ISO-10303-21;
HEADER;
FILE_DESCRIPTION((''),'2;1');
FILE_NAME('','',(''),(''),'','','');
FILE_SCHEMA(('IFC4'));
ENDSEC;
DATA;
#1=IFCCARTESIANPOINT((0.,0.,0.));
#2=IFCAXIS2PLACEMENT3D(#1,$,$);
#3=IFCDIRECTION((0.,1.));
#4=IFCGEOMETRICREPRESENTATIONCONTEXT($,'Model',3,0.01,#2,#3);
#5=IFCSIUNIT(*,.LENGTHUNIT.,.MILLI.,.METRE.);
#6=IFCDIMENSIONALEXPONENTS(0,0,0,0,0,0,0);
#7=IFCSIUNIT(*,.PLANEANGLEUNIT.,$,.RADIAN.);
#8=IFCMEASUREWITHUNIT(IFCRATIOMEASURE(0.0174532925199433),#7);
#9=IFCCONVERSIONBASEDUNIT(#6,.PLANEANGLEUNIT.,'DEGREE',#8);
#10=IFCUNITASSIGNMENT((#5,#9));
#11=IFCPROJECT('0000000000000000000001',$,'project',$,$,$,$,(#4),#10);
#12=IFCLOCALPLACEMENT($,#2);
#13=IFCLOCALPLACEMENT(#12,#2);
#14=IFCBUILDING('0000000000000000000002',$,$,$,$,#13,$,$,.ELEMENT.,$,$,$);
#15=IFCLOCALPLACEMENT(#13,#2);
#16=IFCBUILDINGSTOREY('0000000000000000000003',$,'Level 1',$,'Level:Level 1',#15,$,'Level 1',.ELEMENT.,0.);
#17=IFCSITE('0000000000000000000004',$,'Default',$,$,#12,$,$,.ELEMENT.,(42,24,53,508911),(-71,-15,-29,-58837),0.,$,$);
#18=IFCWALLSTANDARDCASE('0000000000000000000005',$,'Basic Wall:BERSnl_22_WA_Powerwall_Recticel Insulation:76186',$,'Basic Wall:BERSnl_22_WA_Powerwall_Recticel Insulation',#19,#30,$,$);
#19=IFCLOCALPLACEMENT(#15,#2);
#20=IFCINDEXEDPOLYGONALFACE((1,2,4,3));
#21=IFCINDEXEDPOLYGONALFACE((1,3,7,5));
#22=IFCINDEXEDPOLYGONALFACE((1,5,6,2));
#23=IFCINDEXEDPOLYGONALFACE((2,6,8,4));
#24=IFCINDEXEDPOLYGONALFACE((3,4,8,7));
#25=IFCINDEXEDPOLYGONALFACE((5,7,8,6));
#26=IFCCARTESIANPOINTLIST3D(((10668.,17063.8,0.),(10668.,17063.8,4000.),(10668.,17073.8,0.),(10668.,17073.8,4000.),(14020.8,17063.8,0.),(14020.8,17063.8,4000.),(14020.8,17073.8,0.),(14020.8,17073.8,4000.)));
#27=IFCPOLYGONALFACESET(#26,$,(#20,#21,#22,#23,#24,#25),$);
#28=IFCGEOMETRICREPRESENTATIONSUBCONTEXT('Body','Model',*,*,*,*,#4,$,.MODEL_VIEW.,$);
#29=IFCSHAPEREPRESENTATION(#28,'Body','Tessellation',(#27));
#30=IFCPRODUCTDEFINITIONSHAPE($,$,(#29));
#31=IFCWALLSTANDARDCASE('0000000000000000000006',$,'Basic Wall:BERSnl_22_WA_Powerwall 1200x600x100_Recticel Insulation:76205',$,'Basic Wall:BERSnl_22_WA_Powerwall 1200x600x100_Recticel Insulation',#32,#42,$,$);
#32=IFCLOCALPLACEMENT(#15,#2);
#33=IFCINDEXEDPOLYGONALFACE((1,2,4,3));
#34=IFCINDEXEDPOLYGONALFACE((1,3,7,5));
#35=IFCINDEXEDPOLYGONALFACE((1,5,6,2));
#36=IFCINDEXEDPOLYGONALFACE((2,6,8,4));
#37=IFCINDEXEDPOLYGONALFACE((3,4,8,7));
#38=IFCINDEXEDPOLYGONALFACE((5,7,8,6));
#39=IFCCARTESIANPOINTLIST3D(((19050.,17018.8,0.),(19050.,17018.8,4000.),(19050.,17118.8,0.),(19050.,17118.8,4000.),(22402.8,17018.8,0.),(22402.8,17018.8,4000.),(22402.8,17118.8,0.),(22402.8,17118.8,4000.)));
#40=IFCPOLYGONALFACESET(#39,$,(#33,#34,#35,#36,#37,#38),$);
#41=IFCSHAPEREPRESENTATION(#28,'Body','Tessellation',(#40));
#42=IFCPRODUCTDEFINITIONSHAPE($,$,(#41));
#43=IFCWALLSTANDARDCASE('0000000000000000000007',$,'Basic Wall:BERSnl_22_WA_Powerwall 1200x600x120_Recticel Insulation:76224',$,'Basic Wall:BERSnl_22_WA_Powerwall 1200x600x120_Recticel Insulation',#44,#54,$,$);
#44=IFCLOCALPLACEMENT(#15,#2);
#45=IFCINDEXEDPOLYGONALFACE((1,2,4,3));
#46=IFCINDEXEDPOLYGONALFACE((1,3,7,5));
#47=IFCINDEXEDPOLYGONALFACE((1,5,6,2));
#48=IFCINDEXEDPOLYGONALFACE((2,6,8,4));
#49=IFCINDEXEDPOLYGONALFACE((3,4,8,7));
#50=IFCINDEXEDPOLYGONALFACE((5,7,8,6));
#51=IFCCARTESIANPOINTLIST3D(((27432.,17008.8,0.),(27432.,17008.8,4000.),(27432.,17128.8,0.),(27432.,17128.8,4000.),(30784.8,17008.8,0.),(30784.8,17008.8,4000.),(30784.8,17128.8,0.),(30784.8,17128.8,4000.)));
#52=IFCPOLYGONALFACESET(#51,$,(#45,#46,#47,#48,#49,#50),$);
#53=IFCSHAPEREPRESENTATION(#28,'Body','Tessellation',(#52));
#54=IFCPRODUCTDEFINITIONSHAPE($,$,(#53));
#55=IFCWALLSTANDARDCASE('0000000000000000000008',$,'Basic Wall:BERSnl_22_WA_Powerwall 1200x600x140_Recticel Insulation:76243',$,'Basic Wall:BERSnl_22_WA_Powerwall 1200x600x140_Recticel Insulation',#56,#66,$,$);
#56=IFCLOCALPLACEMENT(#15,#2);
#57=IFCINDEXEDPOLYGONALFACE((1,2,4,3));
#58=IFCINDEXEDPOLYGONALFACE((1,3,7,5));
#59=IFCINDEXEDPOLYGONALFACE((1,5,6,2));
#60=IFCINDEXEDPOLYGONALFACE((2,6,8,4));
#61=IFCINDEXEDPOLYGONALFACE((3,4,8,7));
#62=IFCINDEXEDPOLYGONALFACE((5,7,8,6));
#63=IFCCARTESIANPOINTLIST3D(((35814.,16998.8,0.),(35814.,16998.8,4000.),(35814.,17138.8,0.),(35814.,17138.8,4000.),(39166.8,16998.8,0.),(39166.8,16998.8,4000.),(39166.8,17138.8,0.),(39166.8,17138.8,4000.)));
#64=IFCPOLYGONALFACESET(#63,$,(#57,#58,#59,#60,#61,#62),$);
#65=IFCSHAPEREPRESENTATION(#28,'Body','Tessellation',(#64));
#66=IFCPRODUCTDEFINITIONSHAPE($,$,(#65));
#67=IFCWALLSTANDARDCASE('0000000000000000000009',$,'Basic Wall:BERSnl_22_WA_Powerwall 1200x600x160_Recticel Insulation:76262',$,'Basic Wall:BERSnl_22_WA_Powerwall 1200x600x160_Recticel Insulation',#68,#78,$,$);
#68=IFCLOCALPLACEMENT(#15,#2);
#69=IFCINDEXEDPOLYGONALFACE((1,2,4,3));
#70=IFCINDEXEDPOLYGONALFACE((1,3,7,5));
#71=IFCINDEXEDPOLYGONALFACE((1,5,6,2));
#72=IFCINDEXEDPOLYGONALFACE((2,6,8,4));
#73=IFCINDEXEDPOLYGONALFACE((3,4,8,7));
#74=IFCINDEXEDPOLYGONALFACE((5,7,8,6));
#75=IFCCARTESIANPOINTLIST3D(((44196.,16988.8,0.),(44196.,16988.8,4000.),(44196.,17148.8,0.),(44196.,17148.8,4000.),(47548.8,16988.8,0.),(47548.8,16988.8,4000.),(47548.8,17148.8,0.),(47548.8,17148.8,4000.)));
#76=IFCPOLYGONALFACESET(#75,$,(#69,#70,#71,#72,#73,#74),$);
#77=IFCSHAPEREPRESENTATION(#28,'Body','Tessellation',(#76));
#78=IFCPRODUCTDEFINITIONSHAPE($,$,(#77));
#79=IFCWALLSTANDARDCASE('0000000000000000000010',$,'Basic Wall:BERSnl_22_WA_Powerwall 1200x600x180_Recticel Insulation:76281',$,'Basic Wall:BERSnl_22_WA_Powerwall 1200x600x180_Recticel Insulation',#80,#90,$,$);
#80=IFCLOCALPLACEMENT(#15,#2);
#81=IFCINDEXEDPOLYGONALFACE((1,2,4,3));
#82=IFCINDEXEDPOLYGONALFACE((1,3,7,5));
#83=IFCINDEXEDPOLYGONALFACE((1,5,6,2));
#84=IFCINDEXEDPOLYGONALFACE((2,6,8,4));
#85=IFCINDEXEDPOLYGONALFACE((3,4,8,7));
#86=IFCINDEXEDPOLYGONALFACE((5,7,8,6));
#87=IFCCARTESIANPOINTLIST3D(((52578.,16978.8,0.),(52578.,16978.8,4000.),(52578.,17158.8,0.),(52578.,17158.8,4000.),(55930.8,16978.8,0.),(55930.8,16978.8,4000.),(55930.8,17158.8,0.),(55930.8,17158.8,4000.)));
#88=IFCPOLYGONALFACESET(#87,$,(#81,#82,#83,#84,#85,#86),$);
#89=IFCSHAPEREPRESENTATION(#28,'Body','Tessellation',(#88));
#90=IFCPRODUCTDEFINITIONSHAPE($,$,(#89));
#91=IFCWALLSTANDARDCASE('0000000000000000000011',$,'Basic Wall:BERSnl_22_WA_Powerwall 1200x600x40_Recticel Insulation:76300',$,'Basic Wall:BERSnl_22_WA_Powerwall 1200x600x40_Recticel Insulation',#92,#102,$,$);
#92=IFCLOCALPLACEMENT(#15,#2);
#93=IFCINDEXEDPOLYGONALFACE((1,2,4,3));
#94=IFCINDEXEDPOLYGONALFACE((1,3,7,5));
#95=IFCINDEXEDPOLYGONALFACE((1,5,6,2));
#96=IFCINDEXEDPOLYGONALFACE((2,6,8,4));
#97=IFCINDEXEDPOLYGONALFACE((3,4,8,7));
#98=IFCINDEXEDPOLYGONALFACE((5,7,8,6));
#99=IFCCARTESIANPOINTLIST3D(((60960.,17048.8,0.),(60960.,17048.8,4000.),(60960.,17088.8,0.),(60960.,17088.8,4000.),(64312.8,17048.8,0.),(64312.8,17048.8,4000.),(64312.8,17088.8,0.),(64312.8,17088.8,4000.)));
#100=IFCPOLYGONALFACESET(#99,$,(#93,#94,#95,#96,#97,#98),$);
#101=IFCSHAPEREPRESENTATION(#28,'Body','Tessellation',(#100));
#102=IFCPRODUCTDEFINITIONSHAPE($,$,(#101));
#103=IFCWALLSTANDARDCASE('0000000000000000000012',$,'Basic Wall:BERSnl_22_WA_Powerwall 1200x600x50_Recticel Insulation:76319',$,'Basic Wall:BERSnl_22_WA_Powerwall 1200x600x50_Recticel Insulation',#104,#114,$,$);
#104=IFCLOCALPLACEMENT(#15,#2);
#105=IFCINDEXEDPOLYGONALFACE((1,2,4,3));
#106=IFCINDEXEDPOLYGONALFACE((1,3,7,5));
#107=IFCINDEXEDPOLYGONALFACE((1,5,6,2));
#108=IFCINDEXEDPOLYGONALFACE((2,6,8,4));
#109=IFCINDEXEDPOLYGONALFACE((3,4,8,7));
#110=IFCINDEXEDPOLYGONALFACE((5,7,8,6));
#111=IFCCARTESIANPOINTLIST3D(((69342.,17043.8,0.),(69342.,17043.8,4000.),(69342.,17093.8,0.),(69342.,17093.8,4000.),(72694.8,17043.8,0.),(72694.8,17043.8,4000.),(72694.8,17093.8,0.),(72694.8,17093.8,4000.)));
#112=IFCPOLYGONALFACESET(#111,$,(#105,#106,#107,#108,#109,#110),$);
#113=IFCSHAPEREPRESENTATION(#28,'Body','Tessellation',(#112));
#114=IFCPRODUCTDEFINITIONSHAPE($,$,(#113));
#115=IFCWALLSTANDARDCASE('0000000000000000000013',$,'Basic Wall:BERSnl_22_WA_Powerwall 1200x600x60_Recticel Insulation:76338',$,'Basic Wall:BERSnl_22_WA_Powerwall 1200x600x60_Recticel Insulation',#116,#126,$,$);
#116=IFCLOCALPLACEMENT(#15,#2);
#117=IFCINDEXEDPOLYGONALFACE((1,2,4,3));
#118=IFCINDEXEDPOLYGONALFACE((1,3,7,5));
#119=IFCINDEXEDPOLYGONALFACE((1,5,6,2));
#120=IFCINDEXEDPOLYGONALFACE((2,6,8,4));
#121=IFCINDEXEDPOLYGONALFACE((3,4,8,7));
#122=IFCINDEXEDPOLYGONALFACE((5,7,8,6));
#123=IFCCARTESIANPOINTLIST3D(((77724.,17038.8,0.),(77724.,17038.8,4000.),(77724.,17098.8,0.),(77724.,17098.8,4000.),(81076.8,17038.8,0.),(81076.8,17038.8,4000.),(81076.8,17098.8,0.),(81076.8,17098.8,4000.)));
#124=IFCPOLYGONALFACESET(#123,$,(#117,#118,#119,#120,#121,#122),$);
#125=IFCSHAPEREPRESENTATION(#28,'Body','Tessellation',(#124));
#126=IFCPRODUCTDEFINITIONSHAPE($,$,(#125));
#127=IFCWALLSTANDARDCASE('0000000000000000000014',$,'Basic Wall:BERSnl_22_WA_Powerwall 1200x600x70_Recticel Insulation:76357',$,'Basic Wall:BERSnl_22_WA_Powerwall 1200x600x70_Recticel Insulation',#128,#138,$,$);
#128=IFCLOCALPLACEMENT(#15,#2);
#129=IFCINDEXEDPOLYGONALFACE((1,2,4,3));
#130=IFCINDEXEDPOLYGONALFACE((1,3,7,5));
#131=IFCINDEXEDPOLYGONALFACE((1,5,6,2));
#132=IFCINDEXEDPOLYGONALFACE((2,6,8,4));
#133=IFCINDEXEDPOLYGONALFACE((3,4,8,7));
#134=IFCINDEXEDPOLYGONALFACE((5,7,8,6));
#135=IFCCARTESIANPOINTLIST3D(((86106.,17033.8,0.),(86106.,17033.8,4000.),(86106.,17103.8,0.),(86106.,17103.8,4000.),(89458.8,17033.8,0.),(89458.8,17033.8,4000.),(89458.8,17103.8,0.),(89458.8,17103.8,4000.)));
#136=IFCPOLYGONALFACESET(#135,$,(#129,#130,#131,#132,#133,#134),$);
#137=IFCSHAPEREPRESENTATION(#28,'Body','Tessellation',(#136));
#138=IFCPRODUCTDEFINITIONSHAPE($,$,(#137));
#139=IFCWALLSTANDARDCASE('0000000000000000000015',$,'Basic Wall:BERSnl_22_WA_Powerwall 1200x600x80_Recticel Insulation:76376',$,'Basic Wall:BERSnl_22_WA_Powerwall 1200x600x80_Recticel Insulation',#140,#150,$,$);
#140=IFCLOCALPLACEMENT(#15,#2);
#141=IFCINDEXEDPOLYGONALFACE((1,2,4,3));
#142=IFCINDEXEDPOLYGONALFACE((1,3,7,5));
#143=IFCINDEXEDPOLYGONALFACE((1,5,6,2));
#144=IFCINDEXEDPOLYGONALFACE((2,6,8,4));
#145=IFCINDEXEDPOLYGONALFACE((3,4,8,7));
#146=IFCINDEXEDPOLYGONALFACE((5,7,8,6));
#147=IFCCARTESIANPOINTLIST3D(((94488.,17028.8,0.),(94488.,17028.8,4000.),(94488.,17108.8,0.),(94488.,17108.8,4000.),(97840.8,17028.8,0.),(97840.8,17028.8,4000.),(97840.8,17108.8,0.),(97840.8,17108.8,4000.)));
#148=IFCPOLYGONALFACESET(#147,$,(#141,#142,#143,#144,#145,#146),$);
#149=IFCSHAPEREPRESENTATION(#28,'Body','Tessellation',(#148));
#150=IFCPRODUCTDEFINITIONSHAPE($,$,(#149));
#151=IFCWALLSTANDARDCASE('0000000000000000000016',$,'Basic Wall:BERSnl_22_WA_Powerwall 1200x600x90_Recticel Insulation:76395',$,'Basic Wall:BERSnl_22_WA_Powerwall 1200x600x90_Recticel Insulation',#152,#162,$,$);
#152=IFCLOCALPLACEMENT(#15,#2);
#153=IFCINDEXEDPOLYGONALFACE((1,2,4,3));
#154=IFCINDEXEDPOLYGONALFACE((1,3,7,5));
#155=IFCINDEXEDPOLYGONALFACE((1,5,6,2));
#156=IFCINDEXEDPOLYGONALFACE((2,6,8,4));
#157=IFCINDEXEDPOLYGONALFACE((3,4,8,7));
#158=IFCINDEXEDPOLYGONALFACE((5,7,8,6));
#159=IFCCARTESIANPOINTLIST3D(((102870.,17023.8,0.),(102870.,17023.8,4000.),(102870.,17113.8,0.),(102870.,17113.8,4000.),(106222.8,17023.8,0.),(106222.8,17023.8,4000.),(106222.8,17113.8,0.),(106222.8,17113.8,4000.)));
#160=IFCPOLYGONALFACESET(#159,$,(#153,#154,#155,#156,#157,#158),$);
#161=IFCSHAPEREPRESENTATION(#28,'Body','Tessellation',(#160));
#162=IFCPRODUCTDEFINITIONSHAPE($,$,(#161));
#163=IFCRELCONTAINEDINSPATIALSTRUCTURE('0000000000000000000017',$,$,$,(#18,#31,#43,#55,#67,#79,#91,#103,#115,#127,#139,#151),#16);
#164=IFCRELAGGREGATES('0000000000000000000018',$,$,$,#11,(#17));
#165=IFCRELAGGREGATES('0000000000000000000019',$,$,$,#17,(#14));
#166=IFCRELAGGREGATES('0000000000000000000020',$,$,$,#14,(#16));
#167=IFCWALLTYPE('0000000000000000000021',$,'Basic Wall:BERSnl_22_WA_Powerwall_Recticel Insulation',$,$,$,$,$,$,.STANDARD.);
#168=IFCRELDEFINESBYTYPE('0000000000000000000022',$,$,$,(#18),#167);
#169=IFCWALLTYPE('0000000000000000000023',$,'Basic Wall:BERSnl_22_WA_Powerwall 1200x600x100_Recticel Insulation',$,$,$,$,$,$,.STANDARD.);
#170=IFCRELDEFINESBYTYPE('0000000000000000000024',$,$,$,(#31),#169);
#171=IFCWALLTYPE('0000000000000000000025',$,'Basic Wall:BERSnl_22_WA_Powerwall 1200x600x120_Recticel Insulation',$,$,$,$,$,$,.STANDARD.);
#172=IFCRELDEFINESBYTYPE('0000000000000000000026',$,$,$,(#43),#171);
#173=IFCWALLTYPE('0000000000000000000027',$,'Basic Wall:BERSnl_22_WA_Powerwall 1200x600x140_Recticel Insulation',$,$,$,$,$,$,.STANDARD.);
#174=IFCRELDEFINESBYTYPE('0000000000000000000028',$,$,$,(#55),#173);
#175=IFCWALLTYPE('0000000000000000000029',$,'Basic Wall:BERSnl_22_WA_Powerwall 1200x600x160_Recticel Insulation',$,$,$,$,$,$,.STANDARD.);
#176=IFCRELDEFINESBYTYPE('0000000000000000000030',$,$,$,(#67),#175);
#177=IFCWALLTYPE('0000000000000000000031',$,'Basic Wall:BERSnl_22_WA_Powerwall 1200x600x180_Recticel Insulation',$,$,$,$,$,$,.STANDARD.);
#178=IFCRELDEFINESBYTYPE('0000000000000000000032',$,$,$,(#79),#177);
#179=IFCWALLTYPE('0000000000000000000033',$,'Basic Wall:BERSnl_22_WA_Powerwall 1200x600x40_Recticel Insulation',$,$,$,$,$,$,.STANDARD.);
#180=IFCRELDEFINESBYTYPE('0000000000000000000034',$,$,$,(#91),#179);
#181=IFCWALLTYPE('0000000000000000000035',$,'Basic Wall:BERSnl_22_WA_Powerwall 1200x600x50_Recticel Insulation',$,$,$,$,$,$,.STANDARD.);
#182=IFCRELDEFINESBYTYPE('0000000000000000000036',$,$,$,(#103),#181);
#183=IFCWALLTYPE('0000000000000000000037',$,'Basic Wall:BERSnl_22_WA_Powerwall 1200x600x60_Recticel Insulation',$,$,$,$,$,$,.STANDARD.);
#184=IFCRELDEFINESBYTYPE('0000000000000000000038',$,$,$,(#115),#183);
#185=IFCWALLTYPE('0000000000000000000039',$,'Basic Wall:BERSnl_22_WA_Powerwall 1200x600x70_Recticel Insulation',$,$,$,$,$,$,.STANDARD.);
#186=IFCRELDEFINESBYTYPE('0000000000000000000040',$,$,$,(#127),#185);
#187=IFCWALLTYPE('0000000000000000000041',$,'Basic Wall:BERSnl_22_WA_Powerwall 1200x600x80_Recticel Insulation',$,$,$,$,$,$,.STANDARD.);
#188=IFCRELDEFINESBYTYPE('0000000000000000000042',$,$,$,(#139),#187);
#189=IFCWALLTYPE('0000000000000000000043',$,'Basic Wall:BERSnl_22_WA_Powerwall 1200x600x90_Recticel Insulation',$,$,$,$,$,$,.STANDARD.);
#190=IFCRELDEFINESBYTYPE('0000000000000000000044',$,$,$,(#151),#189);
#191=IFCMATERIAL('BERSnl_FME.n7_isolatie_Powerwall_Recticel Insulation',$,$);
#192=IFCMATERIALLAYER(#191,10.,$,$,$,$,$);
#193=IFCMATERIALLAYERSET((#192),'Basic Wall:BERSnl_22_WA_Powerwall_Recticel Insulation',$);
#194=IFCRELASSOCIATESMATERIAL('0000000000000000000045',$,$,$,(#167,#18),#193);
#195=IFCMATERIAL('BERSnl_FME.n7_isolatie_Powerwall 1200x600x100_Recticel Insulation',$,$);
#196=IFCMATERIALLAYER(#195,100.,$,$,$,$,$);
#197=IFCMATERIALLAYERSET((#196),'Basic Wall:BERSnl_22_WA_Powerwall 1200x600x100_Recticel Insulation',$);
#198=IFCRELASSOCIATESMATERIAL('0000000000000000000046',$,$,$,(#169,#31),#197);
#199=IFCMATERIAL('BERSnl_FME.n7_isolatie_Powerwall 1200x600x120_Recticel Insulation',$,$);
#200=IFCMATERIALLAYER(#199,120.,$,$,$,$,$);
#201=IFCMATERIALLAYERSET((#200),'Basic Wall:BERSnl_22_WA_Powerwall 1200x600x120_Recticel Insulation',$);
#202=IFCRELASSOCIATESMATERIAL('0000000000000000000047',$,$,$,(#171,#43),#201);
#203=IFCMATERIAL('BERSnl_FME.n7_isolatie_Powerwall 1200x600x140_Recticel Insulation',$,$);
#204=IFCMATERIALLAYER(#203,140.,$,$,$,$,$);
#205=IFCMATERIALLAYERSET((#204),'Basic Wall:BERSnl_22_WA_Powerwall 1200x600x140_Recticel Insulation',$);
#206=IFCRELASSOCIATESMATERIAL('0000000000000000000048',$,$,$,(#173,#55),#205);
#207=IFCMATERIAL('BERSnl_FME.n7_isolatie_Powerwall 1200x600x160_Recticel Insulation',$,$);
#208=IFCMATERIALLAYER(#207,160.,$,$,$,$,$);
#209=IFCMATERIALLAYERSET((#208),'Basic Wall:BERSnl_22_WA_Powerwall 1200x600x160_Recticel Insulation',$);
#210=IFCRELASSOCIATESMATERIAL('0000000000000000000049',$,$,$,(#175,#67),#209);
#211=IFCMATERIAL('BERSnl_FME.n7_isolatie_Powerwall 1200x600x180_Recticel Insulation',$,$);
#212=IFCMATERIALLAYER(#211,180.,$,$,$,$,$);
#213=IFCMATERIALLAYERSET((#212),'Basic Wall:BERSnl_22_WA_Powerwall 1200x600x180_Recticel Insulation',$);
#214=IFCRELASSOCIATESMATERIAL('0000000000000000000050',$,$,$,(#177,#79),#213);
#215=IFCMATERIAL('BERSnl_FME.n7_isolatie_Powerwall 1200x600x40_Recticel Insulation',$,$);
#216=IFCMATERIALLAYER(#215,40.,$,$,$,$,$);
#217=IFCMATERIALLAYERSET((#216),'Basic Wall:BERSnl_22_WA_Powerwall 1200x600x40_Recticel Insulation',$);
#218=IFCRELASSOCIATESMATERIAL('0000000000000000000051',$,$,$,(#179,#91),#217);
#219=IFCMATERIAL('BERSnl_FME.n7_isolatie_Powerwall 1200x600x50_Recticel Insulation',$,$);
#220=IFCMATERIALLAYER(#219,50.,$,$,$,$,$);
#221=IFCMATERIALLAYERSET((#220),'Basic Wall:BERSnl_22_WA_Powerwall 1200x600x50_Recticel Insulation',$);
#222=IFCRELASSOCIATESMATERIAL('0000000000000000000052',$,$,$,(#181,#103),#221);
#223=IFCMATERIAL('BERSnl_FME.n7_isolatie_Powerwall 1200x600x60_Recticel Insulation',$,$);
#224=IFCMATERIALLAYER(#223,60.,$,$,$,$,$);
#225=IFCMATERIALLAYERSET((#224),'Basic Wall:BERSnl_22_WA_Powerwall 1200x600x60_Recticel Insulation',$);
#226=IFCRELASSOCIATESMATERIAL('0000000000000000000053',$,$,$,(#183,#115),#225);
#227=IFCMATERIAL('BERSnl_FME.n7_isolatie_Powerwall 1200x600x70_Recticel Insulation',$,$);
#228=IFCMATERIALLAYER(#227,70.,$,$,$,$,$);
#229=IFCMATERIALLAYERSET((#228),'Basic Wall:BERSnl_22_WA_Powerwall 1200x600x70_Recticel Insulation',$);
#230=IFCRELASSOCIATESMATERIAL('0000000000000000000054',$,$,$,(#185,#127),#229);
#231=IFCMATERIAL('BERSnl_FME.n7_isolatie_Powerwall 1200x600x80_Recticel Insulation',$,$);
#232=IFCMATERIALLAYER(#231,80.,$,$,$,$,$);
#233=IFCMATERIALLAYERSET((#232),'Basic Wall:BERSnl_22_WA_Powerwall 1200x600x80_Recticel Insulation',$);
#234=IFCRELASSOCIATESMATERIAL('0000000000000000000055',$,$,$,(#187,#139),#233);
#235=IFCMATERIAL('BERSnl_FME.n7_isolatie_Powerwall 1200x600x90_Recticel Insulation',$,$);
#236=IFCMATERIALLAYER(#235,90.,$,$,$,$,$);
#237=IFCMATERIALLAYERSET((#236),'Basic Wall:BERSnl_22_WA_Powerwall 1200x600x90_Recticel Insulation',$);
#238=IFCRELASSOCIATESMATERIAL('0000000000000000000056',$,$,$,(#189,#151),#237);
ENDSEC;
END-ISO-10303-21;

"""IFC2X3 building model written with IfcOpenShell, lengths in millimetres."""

from ifc_helpers import new_model, entity, si_unit, converted_unit, direction, frame, frame_2d, origin, place, context, subcontext, project, spatial, rectangle, extrude, material, layer, layer_set, layer_usage, type_object, element, save


model = new_model("IFC2X3")

# Units and contexts
model_context = context("Model", 3, precision=0.01, world=origin(), true_north=direction((0.0, 1.0)))
body_context = subcontext(model_context, "Body", "Model", "MODEL_VIEW")
ifc_project = project(units=[si_unit("LENGTHUNIT", "METRE", prefix="MILLI"), converted_unit("PLANEANGLEUNIT", "DEGREE", entity("IfcRatioMeasure", 0.0174532925199433), si_unit("PLANEANGLEUNIT", "RADIAN"), dimensions=[0, 0, 0, 0, 0, 0, 0])], contexts=[model_context])

# Site, building, storey
site_placement = place(None, origin())
site = spatial("IfcSite", under=ifc_project, at=site_placement, Name="Default", CompositionType="ELEMENT", RefLatitude=(42, 24, 53, 508911), RefLongitude=(-71, -15, -29, -58837), RefElevation=0.0)
building_placement = place(site_placement, origin())
building = spatial("IfcBuilding", under=site, at=building_placement, CompositionType="ELEMENT")
storey_placement = place(building_placement, origin())
storey = spatial("IfcBuildingStorey", under=building, at=storey_placement, Name="Level 1", ObjectType="Level:Level 1", LongName="Level 1", CompositionType="ELEMENT", Elevation=0.0)

# Walls
ifc_material_1 = material(Name="BERSnl_FME.n7_isolatie_Powerwall_Recticel Insulation")
ifc_layer_1 = layer(ifc_material_1, 10.0)
ifc_layer_set_1 = layer_set([ifc_layer_1], Name="Basic Wall:BERSnl_22_WA_Powerwall_Recticel Insulation")
ifc_layer_usage_1 = layer_usage(ifc_layer_set_1, "AXIS2", "NEGATIVE", 5.0)
wall_type_1 = type_object("IfcWallType", Name="Basic Wall:BERSnl_22_WA_Powerwall_Recticel Insulation", PredefinedType="STANDARD", material=ifc_layer_set_1)
wall_1_placement = place(storey_placement, frame((10668.0, 17068.8, 0.0)))
element("IfcWallStandardCase", 1, at=wall_1_placement, inside=storey, type_object=wall_type_1, material=ifc_layer_usage_1, Name="Basic Wall:BERSnl_22_WA_Powerwall_Recticel Insulation:76186", ObjectType="Basic Wall:BERSnl_22_WA_Powerwall_Recticel Insulation", context=body_context, shape_type="SweptSolid", body=[
    extrude(rectangle(XDim=3352.8, YDim=10.0, at=frame_2d((1676.4, 0.0), x_axis=(-1.0, 0.0))), origin(), (0.0, 0.0, 1.0), 4000.0),
])
ifc_material_2 = material(Name="BERSnl_FME.n7_isolatie_Powerwall 1200x600x100_Recticel Insulation")
ifc_layer_2 = layer(ifc_material_2, 100.0)
ifc_layer_set_2 = layer_set([ifc_layer_2], Name="Basic Wall:BERSnl_22_WA_Powerwall 1200x600x100_Recticel Insulation")
ifc_layer_usage_2 = layer_usage(ifc_layer_set_2, "AXIS2", "NEGATIVE", 50.0)
wall_type_2 = type_object("IfcWallType", Name="Basic Wall:BERSnl_22_WA_Powerwall 1200x600x100_Recticel Insulation", PredefinedType="STANDARD", material=ifc_layer_set_2)
wall_2_placement = place(storey_placement, frame((19050.0, 17068.8, 0.0)))
element("IfcWallStandardCase", 2, at=wall_2_placement, inside=storey, type_object=wall_type_2, material=ifc_layer_usage_2, Name="Basic Wall:BERSnl_22_WA_Powerwall 1200x600x100_Recticel Insulation:76205", ObjectType="Basic Wall:BERSnl_22_WA_Powerwall 1200x600x100_Recticel Insulation", context=body_context, shape_type="SweptSolid", body=[
    extrude(rectangle(XDim=3352.8, YDim=100.0, at=frame_2d((1676.4, 0.0), x_axis=(-1.0, 0.0))), origin(), (0.0, 0.0, 1.0), 4000.0),
])
ifc_material_3 = material(Name="BERSnl_FME.n7_isolatie_Powerwall 1200x600x120_Recticel Insulation")
ifc_layer_3 = layer(ifc_material_3, 120.0)
ifc_layer_set_3 = layer_set([ifc_layer_3], Name="Basic Wall:BERSnl_22_WA_Powerwall 1200x600x120_Recticel Insulation")
ifc_layer_usage_3 = layer_usage(ifc_layer_set_3, "AXIS2", "NEGATIVE", 60.0)
wall_type_3 = type_object("IfcWallType", Name="Basic Wall:BERSnl_22_WA_Powerwall 1200x600x120_Recticel Insulation", PredefinedType="STANDARD", material=ifc_layer_set_3)
wall_3_placement = place(storey_placement, frame((27432.0, 17068.8, 0.0)))
element("IfcWallStandardCase", 3, at=wall_3_placement, inside=storey, type_object=wall_type_3, material=ifc_layer_usage_3, Name="Basic Wall:BERSnl_22_WA_Powerwall 1200x600x120_Recticel Insulation:76224", ObjectType="Basic Wall:BERSnl_22_WA_Powerwall 1200x600x120_Recticel Insulation", context=body_context, shape_type="SweptSolid", body=[
    extrude(rectangle(XDim=3352.8, YDim=120.0, at=frame_2d((1676.4, 0.0), x_axis=(-1.0, 0.0))), origin(), (0.0, 0.0, 1.0), 4000.0),
])
ifc_material_4 = material(Name="BERSnl_FME.n7_isolatie_Powerwall 1200x600x140_Recticel Insulation")
ifc_layer_4 = layer(ifc_material_4, 140.0)
ifc_layer_set_4 = layer_set([ifc_layer_4], Name="Basic Wall:BERSnl_22_WA_Powerwall 1200x600x140_Recticel Insulation")
ifc_layer_usage_4 = layer_usage(ifc_layer_set_4, "AXIS2", "NEGATIVE", 70.0)
wall_type_4 = type_object("IfcWallType", Name="Basic Wall:BERSnl_22_WA_Powerwall 1200x600x140_Recticel Insulation", PredefinedType="STANDARD", material=ifc_layer_set_4)
wall_4_placement = place(storey_placement, frame((35814.0, 17068.8, 0.0)))
element("IfcWallStandardCase", 4, at=wall_4_placement, inside=storey, type_object=wall_type_4, material=ifc_layer_usage_4, Name="Basic Wall:BERSnl_22_WA_Powerwall 1200x600x140_Recticel Insulation:76243", ObjectType="Basic Wall:BERSnl_22_WA_Powerwall 1200x600x140_Recticel Insulation", context=body_context, shape_type="SweptSolid", body=[
    extrude(rectangle(XDim=3352.8, YDim=140.0, at=frame_2d((1676.4, 0.0), x_axis=(-1.0, 0.0))), origin(), (0.0, 0.0, 1.0), 4000.0),
])
ifc_material_5 = material(Name="BERSnl_FME.n7_isolatie_Powerwall 1200x600x160_Recticel Insulation")
ifc_layer_5 = layer(ifc_material_5, 160.0)
ifc_layer_set_5 = layer_set([ifc_layer_5], Name="Basic Wall:BERSnl_22_WA_Powerwall 1200x600x160_Recticel Insulation")
ifc_layer_usage_5 = layer_usage(ifc_layer_set_5, "AXIS2", "NEGATIVE", 80.0)
wall_type_5 = type_object("IfcWallType", Name="Basic Wall:BERSnl_22_WA_Powerwall 1200x600x160_Recticel Insulation", PredefinedType="STANDARD", material=ifc_layer_set_5)
wall_5_placement = place(storey_placement, frame((44196.0, 17068.8, 0.0)))
element("IfcWallStandardCase", 5, at=wall_5_placement, inside=storey, type_object=wall_type_5, material=ifc_layer_usage_5, Name="Basic Wall:BERSnl_22_WA_Powerwall 1200x600x160_Recticel Insulation:76262", ObjectType="Basic Wall:BERSnl_22_WA_Powerwall 1200x600x160_Recticel Insulation", context=body_context, shape_type="SweptSolid", body=[
    extrude(rectangle(XDim=3352.8, YDim=160.0, at=frame_2d((1676.4, 0.0), x_axis=(-1.0, 0.0))), origin(), (0.0, 0.0, 1.0), 4000.0),
])
ifc_material_6 = material(Name="BERSnl_FME.n7_isolatie_Powerwall 1200x600x180_Recticel Insulation")
ifc_layer_6 = layer(ifc_material_6, 180.0)
ifc_layer_set_6 = layer_set([ifc_layer_6], Name="Basic Wall:BERSnl_22_WA_Powerwall 1200x600x180_Recticel Insulation")
ifc_layer_usage_6 = layer_usage(ifc_layer_set_6, "AXIS2", "NEGATIVE", 90.0)
wall_type_6 = type_object("IfcWallType", Name="Basic Wall:BERSnl_22_WA_Powerwall 1200x600x180_Recticel Insulation", PredefinedType="STANDARD", material=ifc_layer_set_6)
wall_6_placement = place(storey_placement, frame((52578.0, 17068.8, 0.0)))
element("IfcWallStandardCase", 6, at=wall_6_placement, inside=storey, type_object=wall_type_6, material=ifc_layer_usage_6, Name="Basic Wall:BERSnl_22_WA_Powerwall 1200x600x180_Recticel Insulation:76281", ObjectType="Basic Wall:BERSnl_22_WA_Powerwall 1200x600x180_Recticel Insulation", context=body_context, shape_type="SweptSolid", body=[
    extrude(rectangle(XDim=3352.8, YDim=180.0, at=frame_2d((1676.4, 0.0), x_axis=(-1.0, 0.0))), origin(), (0.0, 0.0, 1.0), 4000.0),
])
ifc_material_7 = material(Name="BERSnl_FME.n7_isolatie_Powerwall 1200x600x40_Recticel Insulation")
ifc_layer_7 = layer(ifc_material_7, 40.0)
ifc_layer_set_7 = layer_set([ifc_layer_7], Name="Basic Wall:BERSnl_22_WA_Powerwall 1200x600x40_Recticel Insulation")
ifc_layer_usage_7 = layer_usage(ifc_layer_set_7, "AXIS2", "NEGATIVE", 20.0)
wall_type_7 = type_object("IfcWallType", Name="Basic Wall:BERSnl_22_WA_Powerwall 1200x600x40_Recticel Insulation", PredefinedType="STANDARD", material=ifc_layer_set_7)
wall_7_placement = place(storey_placement, frame((60960.0, 17068.8, 0.0)))
element("IfcWallStandardCase", 7, at=wall_7_placement, inside=storey, type_object=wall_type_7, material=ifc_layer_usage_7, Name="Basic Wall:BERSnl_22_WA_Powerwall 1200x600x40_Recticel Insulation:76300", ObjectType="Basic Wall:BERSnl_22_WA_Powerwall 1200x600x40_Recticel Insulation", context=body_context, shape_type="SweptSolid", body=[
    extrude(rectangle(XDim=3352.8, YDim=40.0, at=frame_2d((1676.4, 0.0), x_axis=(-1.0, 0.0))), origin(), (0.0, 0.0, 1.0), 4000.0),
])
ifc_material_8 = material(Name="BERSnl_FME.n7_isolatie_Powerwall 1200x600x50_Recticel Insulation")
ifc_layer_8 = layer(ifc_material_8, 50.0)
ifc_layer_set_8 = layer_set([ifc_layer_8], Name="Basic Wall:BERSnl_22_WA_Powerwall 1200x600x50_Recticel Insulation")
ifc_layer_usage_8 = layer_usage(ifc_layer_set_8, "AXIS2", "NEGATIVE", 25.0)
wall_type_8 = type_object("IfcWallType", Name="Basic Wall:BERSnl_22_WA_Powerwall 1200x600x50_Recticel Insulation", PredefinedType="STANDARD", material=ifc_layer_set_8)
wall_8_placement = place(storey_placement, frame((69342.0, 17068.8, 0.0)))
element("IfcWallStandardCase", 8, at=wall_8_placement, inside=storey, type_object=wall_type_8, material=ifc_layer_usage_8, Name="Basic Wall:BERSnl_22_WA_Powerwall 1200x600x50_Recticel Insulation:76319", ObjectType="Basic Wall:BERSnl_22_WA_Powerwall 1200x600x50_Recticel Insulation", context=body_context, shape_type="SweptSolid", body=[
    extrude(rectangle(XDim=3352.8, YDim=50.0, at=frame_2d((1676.4, 0.0), x_axis=(-1.0, 0.0))), origin(), (0.0, 0.0, 1.0), 4000.0),
])
ifc_material_9 = material(Name="BERSnl_FME.n7_isolatie_Powerwall 1200x600x60_Recticel Insulation")
ifc_layer_9 = layer(ifc_material_9, 60.0)
ifc_layer_set_9 = layer_set([ifc_layer_9], Name="Basic Wall:BERSnl_22_WA_Powerwall 1200x600x60_Recticel Insulation")
ifc_layer_usage_9 = layer_usage(ifc_layer_set_9, "AXIS2", "NEGATIVE", 30.0)
wall_type_9 = type_object("IfcWallType", Name="Basic Wall:BERSnl_22_WA_Powerwall 1200x600x60_Recticel Insulation", PredefinedType="STANDARD", material=ifc_layer_set_9)
wall_9_placement = place(storey_placement, frame((77724.0, 17068.8, 0.0)))
element("IfcWallStandardCase", 9, at=wall_9_placement, inside=storey, type_object=wall_type_9, material=ifc_layer_usage_9, Name="Basic Wall:BERSnl_22_WA_Powerwall 1200x600x60_Recticel Insulation:76338", ObjectType="Basic Wall:BERSnl_22_WA_Powerwall 1200x600x60_Recticel Insulation", context=body_context, shape_type="SweptSolid", body=[
    extrude(rectangle(XDim=3352.8, YDim=60.0, at=frame_2d((1676.4, 0.0), x_axis=(-1.0, 0.0))), origin(), (0.0, 0.0, 1.0), 4000.0),
])
ifc_material_10 = material(Name="BERSnl_FME.n7_isolatie_Powerwall 1200x600x70_Recticel Insulation")
ifc_layer_10 = layer(ifc_material_10, 70.0)
ifc_layer_set_10 = layer_set([ifc_layer_10], Name="Basic Wall:BERSnl_22_WA_Powerwall 1200x600x70_Recticel Insulation")
ifc_layer_usage_10 = layer_usage(ifc_layer_set_10, "AXIS2", "NEGATIVE", 35.0)
wall_type_10 = type_object("IfcWallType", Name="Basic Wall:BERSnl_22_WA_Powerwall 1200x600x70_Recticel Insulation", PredefinedType="STANDARD", material=ifc_layer_set_10)
wall_10_placement = place(storey_placement, frame((86106.0, 17068.8, 0.0)))
element("IfcWallStandardCase", 10, at=wall_10_placement, inside=storey, type_object=wall_type_10, material=ifc_layer_usage_10, Name="Basic Wall:BERSnl_22_WA_Powerwall 1200x600x70_Recticel Insulation:76357", ObjectType="Basic Wall:BERSnl_22_WA_Powerwall 1200x600x70_Recticel Insulation", context=body_context, shape_type="SweptSolid", body=[
    extrude(rectangle(XDim=3352.8, YDim=70.0, at=frame_2d((1676.4, 0.0), x_axis=(-1.0, 0.0))), origin(), (0.0, 0.0, 1.0), 4000.0),
])
ifc_material_11 = material(Name="BERSnl_FME.n7_isolatie_Powerwall 1200x600x80_Recticel Insulation")
ifc_layer_11 = layer(ifc_material_11, 80.0)
ifc_layer_set_11 = layer_set([ifc_layer_11], Name="Basic Wall:BERSnl_22_WA_Powerwall 1200x600x80_Recticel Insulation")
ifc_layer_usage_11 = layer_usage(ifc_layer_set_11, "AXIS2", "NEGATIVE", 40.0)
wall_type_11 = type_object("IfcWallType", Name="Basic Wall:BERSnl_22_WA_Powerwall 1200x600x80_Recticel Insulation", PredefinedType="STANDARD", material=ifc_layer_set_11)
wall_11_placement = place(storey_placement, frame((94488.0, 17068.8, 0.0)))
element("IfcWallStandardCase", 11, at=wall_11_placement, inside=storey, type_object=wall_type_11, material=ifc_layer_usage_11, Name="Basic Wall:BERSnl_22_WA_Powerwall 1200x600x80_Recticel Insulation:76376", ObjectType="Basic Wall:BERSnl_22_WA_Powerwall 1200x600x80_Recticel Insulation", context=body_context, shape_type="SweptSolid", body=[
    extrude(rectangle(XDim=3352.8, YDim=80.0, at=frame_2d((1676.4, 0.0), x_axis=(-1.0, 0.0))), origin(), (0.0, 0.0, 1.0), 4000.0),
])
ifc_material_12 = material(Name="BERSnl_FME.n7_isolatie_Powerwall 1200x600x90_Recticel Insulation")
ifc_layer_12 = layer(ifc_material_12, 90.0)
ifc_layer_set_12 = layer_set([ifc_layer_12], Name="Basic Wall:BERSnl_22_WA_Powerwall 1200x600x90_Recticel Insulation")
ifc_layer_usage_12 = layer_usage(ifc_layer_set_12, "AXIS2", "NEGATIVE", 45.0)
wall_type_12 = type_object("IfcWallType", Name="Basic Wall:BERSnl_22_WA_Powerwall 1200x600x90_Recticel Insulation", PredefinedType="STANDARD", material=ifc_layer_set_12)
wall_12_placement = place(storey_placement, frame((102870.0, 17068.8, 0.0)))
element("IfcWallStandardCase", 12, at=wall_12_placement, inside=storey, type_object=wall_type_12, material=ifc_layer_usage_12, Name="Basic Wall:BERSnl_22_WA_Powerwall 1200x600x90_Recticel Insulation:76395", ObjectType="Basic Wall:BERSnl_22_WA_Powerwall 1200x600x90_Recticel Insulation", context=body_context, shape_type="SweptSolid", body=[
    extrude(rectangle(XDim=3352.8, YDim=90.0, at=frame_2d((1676.4, 0.0), x_axis=(-1.0, 0.0))), origin(), (0.0, 0.0, 1.0), 4000.0),
])

save(model, "model.ifc")
